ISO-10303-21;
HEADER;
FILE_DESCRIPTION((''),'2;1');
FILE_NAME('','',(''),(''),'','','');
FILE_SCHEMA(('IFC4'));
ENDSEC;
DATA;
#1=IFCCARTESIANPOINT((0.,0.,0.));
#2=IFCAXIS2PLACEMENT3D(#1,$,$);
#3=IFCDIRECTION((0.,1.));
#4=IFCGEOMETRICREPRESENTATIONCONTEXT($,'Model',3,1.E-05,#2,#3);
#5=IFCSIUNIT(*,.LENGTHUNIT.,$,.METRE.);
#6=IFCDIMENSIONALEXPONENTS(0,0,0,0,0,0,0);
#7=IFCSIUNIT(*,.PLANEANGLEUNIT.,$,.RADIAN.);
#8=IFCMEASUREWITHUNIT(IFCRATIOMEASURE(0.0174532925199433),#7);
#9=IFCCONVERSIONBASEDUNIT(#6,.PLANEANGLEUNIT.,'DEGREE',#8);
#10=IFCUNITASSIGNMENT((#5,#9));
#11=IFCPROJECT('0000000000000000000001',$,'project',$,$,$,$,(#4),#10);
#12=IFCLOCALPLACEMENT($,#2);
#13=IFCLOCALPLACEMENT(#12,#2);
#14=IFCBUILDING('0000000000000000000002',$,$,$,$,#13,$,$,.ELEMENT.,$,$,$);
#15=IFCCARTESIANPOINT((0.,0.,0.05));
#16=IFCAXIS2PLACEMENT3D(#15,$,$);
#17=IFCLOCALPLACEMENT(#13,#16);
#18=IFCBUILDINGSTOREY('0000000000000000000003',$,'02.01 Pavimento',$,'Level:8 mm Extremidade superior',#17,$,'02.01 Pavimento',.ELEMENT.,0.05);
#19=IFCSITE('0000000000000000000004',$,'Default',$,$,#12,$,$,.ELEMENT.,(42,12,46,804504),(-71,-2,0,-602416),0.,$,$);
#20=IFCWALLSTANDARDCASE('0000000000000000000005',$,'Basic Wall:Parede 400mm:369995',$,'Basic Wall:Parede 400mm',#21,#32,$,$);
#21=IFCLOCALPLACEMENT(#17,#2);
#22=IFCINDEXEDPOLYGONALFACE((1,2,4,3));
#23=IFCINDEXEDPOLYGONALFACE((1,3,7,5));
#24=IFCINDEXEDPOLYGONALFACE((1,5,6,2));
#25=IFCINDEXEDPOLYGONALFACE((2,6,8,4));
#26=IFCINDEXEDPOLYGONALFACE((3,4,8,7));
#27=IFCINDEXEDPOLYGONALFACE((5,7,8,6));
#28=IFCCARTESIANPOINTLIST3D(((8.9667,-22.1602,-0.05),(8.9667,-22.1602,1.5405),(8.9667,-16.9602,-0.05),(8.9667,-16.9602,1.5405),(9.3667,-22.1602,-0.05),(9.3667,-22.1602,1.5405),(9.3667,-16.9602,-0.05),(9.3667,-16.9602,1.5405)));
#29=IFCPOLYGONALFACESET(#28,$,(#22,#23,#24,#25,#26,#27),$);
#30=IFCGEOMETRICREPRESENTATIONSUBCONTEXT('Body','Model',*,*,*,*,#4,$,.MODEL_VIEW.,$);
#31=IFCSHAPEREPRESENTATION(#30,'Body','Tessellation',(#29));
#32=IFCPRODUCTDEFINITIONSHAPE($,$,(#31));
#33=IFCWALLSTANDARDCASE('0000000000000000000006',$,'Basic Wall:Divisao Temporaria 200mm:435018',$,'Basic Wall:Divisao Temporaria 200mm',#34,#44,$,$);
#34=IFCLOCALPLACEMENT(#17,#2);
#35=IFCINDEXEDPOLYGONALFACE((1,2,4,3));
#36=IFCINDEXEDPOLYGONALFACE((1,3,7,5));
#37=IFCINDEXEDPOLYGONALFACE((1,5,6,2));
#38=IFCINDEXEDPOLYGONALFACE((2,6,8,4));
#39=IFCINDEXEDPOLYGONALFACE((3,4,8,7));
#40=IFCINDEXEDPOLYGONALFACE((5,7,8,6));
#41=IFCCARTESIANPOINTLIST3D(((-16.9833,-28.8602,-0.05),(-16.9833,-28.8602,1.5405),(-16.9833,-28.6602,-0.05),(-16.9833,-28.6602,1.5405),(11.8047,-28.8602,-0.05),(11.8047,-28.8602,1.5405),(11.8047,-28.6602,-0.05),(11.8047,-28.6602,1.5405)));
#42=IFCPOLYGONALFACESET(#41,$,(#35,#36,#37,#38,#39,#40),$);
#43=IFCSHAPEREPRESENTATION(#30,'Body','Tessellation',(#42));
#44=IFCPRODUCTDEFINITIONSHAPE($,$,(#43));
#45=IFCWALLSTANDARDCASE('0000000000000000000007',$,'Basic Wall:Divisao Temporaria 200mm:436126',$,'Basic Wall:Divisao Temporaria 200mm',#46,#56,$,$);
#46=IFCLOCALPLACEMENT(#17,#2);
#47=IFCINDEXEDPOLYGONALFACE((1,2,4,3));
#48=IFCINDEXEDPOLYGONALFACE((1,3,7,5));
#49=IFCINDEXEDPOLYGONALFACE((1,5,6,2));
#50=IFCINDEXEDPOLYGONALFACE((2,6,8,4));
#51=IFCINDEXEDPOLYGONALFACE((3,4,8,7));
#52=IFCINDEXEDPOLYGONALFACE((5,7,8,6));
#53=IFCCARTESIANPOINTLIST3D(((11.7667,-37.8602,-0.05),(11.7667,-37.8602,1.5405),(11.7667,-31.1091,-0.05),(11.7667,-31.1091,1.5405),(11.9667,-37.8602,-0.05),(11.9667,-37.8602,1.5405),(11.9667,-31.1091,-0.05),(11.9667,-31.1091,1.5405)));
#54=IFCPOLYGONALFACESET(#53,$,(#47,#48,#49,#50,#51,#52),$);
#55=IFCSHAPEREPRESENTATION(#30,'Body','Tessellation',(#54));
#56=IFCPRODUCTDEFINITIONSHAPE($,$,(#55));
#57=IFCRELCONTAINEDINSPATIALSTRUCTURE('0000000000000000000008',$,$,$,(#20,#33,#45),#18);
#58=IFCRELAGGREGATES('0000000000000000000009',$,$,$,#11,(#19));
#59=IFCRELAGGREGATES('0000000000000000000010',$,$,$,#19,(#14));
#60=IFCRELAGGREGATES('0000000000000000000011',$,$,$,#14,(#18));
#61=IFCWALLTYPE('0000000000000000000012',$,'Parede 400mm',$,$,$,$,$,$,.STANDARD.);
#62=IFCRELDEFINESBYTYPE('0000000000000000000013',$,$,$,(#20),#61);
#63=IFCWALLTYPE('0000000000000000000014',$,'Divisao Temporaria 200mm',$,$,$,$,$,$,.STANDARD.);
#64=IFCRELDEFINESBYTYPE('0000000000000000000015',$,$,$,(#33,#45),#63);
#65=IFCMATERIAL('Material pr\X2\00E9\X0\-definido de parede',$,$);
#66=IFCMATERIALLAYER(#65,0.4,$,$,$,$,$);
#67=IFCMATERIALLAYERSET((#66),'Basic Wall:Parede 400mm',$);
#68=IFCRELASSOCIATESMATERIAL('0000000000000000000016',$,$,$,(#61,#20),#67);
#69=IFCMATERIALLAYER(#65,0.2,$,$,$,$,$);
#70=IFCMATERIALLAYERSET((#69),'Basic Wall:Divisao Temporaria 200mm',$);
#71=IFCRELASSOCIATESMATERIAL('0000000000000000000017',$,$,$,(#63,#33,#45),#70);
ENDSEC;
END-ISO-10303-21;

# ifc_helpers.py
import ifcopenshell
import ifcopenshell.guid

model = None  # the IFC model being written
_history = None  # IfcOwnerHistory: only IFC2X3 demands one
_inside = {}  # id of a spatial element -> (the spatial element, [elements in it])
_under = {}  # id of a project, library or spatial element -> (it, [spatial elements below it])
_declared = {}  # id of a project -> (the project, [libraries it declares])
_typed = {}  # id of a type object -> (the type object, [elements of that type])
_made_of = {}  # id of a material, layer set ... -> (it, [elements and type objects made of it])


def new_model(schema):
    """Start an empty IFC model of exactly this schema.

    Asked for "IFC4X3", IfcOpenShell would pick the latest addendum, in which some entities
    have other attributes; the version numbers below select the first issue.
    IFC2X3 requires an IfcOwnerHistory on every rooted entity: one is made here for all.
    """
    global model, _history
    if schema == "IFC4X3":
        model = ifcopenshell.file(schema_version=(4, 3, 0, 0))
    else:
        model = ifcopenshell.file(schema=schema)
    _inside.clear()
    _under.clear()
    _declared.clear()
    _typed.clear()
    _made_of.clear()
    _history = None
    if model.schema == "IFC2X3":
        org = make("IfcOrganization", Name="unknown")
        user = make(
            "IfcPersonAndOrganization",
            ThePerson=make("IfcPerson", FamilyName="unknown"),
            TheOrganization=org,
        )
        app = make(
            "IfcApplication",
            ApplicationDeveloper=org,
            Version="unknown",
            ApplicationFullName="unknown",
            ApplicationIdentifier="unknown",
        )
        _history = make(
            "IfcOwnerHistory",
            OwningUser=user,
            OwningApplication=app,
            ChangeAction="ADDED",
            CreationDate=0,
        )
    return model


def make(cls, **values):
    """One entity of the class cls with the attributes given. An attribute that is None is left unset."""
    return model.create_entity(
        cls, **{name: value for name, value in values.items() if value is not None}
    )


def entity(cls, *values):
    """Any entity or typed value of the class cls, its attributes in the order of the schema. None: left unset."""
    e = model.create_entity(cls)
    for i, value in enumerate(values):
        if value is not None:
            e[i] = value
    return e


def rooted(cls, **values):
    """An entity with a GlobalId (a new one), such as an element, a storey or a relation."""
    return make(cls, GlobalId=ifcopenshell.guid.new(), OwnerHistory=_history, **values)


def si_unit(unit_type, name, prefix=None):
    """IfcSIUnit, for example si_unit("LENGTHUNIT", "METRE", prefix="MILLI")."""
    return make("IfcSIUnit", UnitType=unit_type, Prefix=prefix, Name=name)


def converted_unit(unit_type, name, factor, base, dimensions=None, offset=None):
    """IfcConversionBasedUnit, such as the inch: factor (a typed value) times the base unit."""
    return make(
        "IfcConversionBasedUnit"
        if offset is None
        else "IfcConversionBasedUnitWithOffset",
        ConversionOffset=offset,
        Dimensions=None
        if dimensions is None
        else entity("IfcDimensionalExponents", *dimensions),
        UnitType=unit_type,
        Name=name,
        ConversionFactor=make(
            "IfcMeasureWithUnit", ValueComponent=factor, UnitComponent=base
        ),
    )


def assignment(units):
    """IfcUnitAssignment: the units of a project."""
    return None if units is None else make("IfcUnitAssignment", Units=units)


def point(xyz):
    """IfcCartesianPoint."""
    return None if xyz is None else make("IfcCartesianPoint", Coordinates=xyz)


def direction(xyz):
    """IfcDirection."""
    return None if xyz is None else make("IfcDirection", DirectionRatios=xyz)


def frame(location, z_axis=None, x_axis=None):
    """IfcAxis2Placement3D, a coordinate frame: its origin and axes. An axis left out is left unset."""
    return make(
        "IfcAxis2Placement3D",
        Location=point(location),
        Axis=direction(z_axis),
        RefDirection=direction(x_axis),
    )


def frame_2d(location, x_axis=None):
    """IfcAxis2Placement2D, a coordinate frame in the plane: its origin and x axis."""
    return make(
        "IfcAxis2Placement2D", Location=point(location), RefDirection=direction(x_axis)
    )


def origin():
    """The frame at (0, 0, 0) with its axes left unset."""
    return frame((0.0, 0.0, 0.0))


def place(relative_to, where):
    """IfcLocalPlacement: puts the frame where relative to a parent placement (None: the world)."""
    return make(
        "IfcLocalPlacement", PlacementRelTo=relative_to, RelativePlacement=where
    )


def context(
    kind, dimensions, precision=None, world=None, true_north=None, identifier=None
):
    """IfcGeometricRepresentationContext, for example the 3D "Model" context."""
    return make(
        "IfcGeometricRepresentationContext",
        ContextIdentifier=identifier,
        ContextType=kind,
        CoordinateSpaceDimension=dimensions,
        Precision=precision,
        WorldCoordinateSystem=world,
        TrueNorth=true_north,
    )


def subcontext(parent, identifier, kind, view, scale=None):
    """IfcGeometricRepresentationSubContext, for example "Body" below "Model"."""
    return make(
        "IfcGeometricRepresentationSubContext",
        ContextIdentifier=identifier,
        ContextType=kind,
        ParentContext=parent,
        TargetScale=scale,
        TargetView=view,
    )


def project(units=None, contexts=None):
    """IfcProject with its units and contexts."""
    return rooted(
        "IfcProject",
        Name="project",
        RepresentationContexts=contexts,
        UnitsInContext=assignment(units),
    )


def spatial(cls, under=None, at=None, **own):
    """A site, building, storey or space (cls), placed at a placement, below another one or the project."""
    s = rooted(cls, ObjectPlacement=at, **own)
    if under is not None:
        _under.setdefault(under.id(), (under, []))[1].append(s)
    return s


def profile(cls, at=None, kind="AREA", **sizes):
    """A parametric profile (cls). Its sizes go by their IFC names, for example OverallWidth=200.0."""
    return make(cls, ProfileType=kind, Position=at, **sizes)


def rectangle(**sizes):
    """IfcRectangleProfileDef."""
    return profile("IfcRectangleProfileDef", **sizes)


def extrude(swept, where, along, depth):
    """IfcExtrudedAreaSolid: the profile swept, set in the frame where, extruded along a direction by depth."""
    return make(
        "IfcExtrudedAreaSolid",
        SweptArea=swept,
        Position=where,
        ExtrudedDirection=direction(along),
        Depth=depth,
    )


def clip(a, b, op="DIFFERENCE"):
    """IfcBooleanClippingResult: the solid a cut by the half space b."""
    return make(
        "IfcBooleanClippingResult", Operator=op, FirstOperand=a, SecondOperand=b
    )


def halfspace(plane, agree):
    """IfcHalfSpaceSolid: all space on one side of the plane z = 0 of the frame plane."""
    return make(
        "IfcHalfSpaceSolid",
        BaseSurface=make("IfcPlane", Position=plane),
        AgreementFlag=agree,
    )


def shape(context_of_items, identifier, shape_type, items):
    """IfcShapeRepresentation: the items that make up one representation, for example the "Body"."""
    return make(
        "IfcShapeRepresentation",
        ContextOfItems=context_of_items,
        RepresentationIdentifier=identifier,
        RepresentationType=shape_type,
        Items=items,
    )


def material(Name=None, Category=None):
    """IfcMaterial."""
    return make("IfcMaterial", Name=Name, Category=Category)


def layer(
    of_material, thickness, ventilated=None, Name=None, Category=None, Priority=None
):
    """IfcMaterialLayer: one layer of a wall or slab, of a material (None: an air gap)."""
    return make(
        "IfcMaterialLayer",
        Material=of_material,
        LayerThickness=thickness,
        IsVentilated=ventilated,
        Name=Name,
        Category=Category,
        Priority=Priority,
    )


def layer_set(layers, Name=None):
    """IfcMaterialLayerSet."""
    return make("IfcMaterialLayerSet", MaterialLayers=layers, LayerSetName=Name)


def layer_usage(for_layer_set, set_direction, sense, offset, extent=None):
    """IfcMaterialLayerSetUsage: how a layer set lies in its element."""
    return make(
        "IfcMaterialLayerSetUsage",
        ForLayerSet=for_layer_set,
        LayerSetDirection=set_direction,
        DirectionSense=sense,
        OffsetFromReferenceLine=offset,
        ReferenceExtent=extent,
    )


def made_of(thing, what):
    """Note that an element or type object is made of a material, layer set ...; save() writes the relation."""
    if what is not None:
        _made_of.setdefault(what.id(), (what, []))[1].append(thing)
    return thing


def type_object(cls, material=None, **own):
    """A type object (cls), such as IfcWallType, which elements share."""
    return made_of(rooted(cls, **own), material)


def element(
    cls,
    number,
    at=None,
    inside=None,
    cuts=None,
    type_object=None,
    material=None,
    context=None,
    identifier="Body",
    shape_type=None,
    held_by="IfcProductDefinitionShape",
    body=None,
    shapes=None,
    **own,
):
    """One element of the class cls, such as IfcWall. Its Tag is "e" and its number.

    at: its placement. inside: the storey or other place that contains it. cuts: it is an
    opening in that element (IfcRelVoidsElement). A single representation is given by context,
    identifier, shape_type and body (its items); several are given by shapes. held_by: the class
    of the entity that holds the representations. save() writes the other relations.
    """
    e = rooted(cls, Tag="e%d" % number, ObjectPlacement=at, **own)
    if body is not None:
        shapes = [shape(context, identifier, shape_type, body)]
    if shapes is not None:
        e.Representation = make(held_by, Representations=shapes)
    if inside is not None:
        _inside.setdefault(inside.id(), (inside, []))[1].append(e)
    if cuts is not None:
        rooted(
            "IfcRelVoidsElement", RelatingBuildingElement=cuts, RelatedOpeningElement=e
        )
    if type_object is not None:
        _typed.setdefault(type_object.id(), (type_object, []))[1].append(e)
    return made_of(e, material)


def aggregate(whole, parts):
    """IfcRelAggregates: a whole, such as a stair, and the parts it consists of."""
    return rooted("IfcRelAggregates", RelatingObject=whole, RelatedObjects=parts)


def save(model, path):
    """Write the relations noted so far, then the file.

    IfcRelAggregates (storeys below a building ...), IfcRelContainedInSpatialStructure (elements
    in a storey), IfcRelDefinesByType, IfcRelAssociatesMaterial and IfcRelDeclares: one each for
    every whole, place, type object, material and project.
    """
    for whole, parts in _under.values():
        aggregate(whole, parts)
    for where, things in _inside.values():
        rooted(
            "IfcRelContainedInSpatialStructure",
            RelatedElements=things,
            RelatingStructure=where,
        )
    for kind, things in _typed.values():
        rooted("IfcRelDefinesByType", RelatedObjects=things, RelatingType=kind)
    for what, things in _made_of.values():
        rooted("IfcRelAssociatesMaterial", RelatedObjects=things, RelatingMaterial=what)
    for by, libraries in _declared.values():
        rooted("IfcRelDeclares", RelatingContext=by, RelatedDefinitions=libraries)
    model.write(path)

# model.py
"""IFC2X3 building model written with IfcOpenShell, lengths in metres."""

from ifc_helpers import new_model, entity, si_unit, converted_unit, direction, frame, frame_2d, origin, place, context, subcontext, project, spatial, rectangle, extrude, clip, halfspace, material, layer, layer_set, layer_usage, type_object, element, save


model = new_model("IFC2X3")

# Units and contexts
model_context = context("Model", 3, precision=1e-05, world=origin(), true_north=direction((0.0, 1.0)))
body_context = subcontext(model_context, "Body", "Model", "MODEL_VIEW")
ifc_project = project(units=[si_unit("LENGTHUNIT", "METRE"), converted_unit("PLANEANGLEUNIT", "DEGREE", entity("IfcRatioMeasure", 0.0174532925199433), si_unit("PLANEANGLEUNIT", "RADIAN"), dimensions=[0, 0, 0, 0, 0, 0, 0])], contexts=[model_context])

# Site, building, storey
site_placement = place(None, origin())
site = spatial("IfcSite", under=ifc_project, at=site_placement, Name="Default", CompositionType="ELEMENT", RefLatitude=(42, 12, 46, 804504), RefLongitude=(-71, -2, 0, -602416), RefElevation=0.0)
building_placement = place(site_placement, origin())
building = spatial("IfcBuilding", under=site, at=building_placement, CompositionType="ELEMENT")
storey_placement = place(building_placement, frame((0.0, 0.0, 0.05)))
storey = spatial("IfcBuildingStorey", under=building, at=storey_placement, Name="02.01 Pavimento", ObjectType="Level:8 mm Extremidade superior", LongName="02.01 Pavimento", CompositionType="ELEMENT", Elevation=0.05)

# Shared definitions
ifc_material = material(Name="Material pré-definido de parede")

# Wall
ifc_layer_1 = layer(ifc_material, 0.4)
ifc_layer_set_1 = layer_set([ifc_layer_1], Name="Basic Wall:Parede 400mm")
ifc_layer_usage_1 = layer_usage(ifc_layer_set_1, "AXIS2", "POSITIVE", -0.2)
wall_type_1 = type_object("IfcWallType", Name="Parede 400mm", PredefinedType="STANDARD", material=ifc_layer_set_1)
wall_1_placement = place(storey_placement, frame((9.1667, -22.1602, -0.05), z_axis=(0.0, 0.0, 1.0), x_axis=(0.0, 1.0, 0.0)))
element("IfcWallStandardCase", 1, at=wall_1_placement, inside=storey, type_object=wall_type_1, material=ifc_layer_usage_1, Name="Basic Wall:Parede 400mm:369995", ObjectType="Basic Wall:Parede 400mm", context=body_context, shape_type="Clipping", body=[
    clip(extrude(rectangle(XDim=5.2, YDim=0.4, at=frame_2d((2.6, 0.0), x_axis=(-1.0, 0.0))), origin(), (0.0, 0.0, 1.0), 1.5905), halfspace(frame((0.0, 0.0, -0.05)), True)),
])

# Walls
ifc_layer_2 = layer(ifc_material, 0.2)
ifc_layer_set_2 = layer_set([ifc_layer_2], Name="Basic Wall:Divisao Temporaria 200mm")
ifc_layer_usage_2 = layer_usage(ifc_layer_set_2, "AXIS2", "POSITIVE", -0.1)
wall_type_2 = type_object("IfcWallType", Name="Divisao Temporaria 200mm", PredefinedType="STANDARD", material=ifc_layer_set_2)
wall_2_placement = place(storey_placement, frame((11.8047, -28.7602, -0.05), z_axis=(0.0, 0.0, 1.0), x_axis=(-1.0, 0.0, 0.0)))
element("IfcWallStandardCase", 2, at=wall_2_placement, inside=storey, type_object=wall_type_2, material=ifc_layer_usage_2, Name="Basic Wall:Divisao Temporaria 200mm:435018", ObjectType="Basic Wall:Divisao Temporaria 200mm", context=body_context, shape_type="Clipping", body=[
    clip(extrude(rectangle(XDim=28.788, YDim=0.2, at=frame_2d((14.394, 0.0), x_axis=(-1.0, 0.0))), origin(), (0.0, 0.0, 1.0), 1.5905), halfspace(frame((0.0, 0.0, -0.05)), True)),
])
ifc_layer_usage_3 = layer_usage(ifc_layer_set_2, "AXIS2", "NEGATIVE", 0.1)
wall_3_placement = place(storey_placement, frame((11.8667, -31.1091, -0.05), z_axis=(0.0, 0.0, 1.0), x_axis=(0.0, -1.0, 0.0)))
element("IfcWallStandardCase", 3, at=wall_3_placement, inside=storey, type_object=wall_type_2, material=ifc_layer_usage_3, Name="Basic Wall:Divisao Temporaria 200mm:436126", ObjectType="Basic Wall:Divisao Temporaria 200mm", context=body_context, shape_type="Clipping", body=[
    clip(extrude(rectangle(XDim=6.7511, YDim=0.2, at=frame_2d((3.3756, 0.0), x_axis=(-1.0, 0.0))), origin(), (0.0, 0.0, 1.0), 1.5905), halfspace(frame((0.0, 0.0, -0.05)), True)),
])

save(model, "model.ifc")
